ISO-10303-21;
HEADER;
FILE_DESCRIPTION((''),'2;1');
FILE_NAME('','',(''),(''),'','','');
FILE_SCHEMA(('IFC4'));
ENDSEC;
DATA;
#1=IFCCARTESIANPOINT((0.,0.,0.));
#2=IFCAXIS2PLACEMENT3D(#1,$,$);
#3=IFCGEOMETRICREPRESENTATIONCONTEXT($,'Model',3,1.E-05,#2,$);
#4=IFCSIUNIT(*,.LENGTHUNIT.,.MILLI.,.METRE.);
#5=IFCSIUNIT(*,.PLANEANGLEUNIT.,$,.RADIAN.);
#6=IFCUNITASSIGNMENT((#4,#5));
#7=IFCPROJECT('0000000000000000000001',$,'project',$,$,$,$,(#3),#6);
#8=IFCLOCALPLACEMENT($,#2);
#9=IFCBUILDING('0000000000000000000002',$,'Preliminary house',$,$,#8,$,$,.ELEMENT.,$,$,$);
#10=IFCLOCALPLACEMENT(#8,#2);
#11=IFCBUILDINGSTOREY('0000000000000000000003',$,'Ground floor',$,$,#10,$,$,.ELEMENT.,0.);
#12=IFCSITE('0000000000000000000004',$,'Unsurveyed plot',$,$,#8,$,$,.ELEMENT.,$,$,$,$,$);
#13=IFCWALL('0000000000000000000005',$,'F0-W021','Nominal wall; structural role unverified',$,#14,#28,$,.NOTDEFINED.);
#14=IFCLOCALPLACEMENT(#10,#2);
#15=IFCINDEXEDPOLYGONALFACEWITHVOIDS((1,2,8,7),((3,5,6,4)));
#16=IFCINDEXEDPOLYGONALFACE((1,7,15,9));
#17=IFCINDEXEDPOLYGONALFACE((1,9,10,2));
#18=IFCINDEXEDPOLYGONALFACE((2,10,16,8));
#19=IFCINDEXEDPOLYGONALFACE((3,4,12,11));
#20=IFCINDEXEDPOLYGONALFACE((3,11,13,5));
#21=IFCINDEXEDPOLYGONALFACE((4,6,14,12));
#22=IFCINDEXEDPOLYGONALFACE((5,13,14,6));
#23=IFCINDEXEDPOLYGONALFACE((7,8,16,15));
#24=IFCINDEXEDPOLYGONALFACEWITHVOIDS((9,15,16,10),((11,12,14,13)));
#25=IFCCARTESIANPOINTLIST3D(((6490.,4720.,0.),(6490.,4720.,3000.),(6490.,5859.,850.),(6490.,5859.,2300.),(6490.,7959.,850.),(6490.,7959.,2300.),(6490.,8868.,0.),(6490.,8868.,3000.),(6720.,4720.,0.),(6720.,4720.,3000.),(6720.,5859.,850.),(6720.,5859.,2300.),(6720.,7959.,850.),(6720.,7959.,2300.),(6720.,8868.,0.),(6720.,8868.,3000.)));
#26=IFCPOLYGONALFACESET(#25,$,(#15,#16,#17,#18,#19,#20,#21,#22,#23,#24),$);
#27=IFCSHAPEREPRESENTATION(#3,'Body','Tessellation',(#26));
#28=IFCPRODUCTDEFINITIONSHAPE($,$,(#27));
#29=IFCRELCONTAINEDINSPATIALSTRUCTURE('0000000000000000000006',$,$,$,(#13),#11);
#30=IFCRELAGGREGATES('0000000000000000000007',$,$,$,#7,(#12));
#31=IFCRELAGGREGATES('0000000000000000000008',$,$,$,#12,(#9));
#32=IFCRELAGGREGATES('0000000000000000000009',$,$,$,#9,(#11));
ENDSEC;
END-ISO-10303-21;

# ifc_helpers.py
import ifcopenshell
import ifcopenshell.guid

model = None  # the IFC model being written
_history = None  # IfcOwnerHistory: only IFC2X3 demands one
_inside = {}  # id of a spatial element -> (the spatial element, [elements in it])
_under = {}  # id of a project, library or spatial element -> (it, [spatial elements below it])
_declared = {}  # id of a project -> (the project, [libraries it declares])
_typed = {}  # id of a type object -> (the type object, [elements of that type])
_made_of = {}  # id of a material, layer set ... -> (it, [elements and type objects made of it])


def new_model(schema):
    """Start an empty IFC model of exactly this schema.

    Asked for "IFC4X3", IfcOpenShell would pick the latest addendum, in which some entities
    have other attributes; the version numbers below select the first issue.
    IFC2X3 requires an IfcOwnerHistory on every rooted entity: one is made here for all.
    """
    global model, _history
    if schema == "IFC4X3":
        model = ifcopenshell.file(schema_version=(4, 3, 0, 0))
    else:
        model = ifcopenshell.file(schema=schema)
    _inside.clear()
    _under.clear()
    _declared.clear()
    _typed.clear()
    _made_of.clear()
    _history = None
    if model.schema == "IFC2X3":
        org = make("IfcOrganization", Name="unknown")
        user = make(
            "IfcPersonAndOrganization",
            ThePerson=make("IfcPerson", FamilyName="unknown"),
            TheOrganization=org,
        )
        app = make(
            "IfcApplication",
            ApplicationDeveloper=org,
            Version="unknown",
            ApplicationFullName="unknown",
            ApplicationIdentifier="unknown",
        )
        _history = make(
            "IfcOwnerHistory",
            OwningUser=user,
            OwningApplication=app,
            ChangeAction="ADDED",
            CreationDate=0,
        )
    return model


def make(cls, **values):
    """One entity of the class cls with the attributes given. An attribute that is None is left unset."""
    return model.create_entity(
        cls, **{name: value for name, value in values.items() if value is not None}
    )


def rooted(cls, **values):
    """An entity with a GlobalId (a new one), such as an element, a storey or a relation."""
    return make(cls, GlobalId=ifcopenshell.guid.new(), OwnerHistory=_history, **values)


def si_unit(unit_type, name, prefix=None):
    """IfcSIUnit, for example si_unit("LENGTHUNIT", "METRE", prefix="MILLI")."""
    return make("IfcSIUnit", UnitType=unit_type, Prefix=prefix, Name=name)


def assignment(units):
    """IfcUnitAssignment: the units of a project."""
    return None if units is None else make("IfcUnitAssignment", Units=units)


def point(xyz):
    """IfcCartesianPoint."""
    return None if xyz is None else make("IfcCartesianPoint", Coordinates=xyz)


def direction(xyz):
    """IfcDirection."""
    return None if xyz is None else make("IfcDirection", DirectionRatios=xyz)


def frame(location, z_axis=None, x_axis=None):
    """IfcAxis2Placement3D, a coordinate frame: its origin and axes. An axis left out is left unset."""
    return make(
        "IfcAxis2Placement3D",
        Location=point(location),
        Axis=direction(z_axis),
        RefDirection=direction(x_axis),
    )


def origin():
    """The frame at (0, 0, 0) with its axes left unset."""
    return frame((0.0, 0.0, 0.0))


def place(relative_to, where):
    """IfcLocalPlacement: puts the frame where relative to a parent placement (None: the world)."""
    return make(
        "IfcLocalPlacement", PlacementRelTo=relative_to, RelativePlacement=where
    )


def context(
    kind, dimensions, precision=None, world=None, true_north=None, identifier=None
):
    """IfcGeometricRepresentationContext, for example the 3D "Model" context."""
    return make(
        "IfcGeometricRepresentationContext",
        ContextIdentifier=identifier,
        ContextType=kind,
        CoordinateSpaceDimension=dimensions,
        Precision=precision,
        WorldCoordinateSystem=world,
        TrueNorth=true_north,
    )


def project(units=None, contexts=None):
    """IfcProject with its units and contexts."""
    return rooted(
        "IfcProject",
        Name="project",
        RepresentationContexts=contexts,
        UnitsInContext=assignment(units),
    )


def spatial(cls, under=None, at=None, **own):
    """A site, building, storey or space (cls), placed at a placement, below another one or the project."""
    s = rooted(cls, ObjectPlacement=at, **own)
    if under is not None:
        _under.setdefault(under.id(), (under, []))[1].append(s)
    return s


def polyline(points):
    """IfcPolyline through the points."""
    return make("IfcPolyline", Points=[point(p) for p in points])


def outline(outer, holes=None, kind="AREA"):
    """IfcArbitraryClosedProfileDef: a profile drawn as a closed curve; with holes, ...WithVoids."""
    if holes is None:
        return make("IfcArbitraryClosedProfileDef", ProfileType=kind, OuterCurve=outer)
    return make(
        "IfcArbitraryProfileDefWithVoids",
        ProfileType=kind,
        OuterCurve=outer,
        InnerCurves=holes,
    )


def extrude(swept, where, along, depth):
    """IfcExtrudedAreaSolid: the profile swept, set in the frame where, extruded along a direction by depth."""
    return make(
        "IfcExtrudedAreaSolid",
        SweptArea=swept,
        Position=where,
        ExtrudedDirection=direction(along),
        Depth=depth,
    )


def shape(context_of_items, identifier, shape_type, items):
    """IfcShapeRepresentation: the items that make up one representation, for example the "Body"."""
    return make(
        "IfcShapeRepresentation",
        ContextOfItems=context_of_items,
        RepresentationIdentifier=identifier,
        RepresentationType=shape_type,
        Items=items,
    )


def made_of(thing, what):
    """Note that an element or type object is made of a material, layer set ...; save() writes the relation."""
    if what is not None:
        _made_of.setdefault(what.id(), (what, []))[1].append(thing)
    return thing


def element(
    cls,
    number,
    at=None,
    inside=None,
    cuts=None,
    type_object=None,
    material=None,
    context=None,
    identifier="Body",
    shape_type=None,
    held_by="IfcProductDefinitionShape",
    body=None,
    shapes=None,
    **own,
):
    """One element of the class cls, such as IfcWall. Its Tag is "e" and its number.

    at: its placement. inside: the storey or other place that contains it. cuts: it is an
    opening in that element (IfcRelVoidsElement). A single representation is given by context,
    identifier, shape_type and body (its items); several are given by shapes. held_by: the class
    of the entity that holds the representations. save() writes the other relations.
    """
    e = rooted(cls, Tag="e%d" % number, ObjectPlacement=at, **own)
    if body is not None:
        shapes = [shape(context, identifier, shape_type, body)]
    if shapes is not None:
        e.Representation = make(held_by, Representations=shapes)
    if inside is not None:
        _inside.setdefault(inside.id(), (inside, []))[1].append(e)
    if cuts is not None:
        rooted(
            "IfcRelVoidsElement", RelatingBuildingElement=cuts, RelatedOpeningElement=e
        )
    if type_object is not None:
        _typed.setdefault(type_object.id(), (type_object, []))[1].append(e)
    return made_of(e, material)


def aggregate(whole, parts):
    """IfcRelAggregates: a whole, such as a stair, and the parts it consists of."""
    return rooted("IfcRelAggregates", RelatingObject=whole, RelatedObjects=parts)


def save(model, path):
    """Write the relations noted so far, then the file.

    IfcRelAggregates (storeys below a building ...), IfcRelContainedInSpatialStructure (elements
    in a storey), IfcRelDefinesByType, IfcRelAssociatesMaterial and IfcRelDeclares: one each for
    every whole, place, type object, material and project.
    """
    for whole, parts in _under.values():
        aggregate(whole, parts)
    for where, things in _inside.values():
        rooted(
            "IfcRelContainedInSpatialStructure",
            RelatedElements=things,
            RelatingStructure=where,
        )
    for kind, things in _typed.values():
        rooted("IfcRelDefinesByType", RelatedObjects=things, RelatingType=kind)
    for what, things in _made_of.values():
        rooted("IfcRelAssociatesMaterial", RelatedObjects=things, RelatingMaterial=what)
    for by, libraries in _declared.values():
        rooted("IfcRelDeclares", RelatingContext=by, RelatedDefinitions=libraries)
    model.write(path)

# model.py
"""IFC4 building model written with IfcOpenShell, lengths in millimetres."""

from ifc_helpers import new_model, si_unit, frame, origin, place, context, project, spatial, polyline, outline, extrude, element, save


model = new_model("IFC4")

# Units and contexts
model_context = context("Model", 3, precision=1e-05, world=origin())
ifc_project = project(units=[si_unit("LENGTHUNIT", "METRE", prefix="MILLI"), si_unit("PLANEANGLEUNIT", "RADIAN")], contexts=[model_context])

# Site, building, storey
placement_1 = place(None, origin())
site = spatial("IfcSite", under=ifc_project, at=placement_1, Name="Unsurveyed plot", CompositionType="ELEMENT")
building = spatial("IfcBuilding", under=site, at=placement_1, Name="Preliminary house", CompositionType="ELEMENT")
placement_2 = place(placement_1, origin())
storey = spatial("IfcBuildingStorey", under=building, at=placement_2, Name="Ground floor", CompositionType="ELEMENT", Elevation=0.0)

# Wall, opening
wall_1 = element("IfcWall", 1, at=placement_2, inside=storey, Name="F0-W021", Description="Nominal wall; structural role unverified", PredefinedType="NOTDEFINED", context=model_context, shape_type="SweptSolid", body=[
    extrude(outline(polyline([(6490.0, 4720.0), (6490.0, 8868.0), (6720.0, 8868.0), (6720.0, 4720.0), (6490.0, 4720.0)])), origin(), (0.0, 0.0, 1.0), 3000.0),
])
element("IfcOpeningElement", 2, at=placement_2, cuts=wall_1, PredefinedType="OPENING", context=model_context, shape_type="SweptSolid", body=[
    extrude(outline(polyline([(7135.0, 5859.0), (7135.0, 7959.0), (6075.0, 7959.0), (6075.0, 5859.0), (7135.0, 5859.0)])), frame((0.0, 0.0, 850.0)), (0.0, 0.0, 1.0), 1450.0),
])

save(model, "model.ifc")
